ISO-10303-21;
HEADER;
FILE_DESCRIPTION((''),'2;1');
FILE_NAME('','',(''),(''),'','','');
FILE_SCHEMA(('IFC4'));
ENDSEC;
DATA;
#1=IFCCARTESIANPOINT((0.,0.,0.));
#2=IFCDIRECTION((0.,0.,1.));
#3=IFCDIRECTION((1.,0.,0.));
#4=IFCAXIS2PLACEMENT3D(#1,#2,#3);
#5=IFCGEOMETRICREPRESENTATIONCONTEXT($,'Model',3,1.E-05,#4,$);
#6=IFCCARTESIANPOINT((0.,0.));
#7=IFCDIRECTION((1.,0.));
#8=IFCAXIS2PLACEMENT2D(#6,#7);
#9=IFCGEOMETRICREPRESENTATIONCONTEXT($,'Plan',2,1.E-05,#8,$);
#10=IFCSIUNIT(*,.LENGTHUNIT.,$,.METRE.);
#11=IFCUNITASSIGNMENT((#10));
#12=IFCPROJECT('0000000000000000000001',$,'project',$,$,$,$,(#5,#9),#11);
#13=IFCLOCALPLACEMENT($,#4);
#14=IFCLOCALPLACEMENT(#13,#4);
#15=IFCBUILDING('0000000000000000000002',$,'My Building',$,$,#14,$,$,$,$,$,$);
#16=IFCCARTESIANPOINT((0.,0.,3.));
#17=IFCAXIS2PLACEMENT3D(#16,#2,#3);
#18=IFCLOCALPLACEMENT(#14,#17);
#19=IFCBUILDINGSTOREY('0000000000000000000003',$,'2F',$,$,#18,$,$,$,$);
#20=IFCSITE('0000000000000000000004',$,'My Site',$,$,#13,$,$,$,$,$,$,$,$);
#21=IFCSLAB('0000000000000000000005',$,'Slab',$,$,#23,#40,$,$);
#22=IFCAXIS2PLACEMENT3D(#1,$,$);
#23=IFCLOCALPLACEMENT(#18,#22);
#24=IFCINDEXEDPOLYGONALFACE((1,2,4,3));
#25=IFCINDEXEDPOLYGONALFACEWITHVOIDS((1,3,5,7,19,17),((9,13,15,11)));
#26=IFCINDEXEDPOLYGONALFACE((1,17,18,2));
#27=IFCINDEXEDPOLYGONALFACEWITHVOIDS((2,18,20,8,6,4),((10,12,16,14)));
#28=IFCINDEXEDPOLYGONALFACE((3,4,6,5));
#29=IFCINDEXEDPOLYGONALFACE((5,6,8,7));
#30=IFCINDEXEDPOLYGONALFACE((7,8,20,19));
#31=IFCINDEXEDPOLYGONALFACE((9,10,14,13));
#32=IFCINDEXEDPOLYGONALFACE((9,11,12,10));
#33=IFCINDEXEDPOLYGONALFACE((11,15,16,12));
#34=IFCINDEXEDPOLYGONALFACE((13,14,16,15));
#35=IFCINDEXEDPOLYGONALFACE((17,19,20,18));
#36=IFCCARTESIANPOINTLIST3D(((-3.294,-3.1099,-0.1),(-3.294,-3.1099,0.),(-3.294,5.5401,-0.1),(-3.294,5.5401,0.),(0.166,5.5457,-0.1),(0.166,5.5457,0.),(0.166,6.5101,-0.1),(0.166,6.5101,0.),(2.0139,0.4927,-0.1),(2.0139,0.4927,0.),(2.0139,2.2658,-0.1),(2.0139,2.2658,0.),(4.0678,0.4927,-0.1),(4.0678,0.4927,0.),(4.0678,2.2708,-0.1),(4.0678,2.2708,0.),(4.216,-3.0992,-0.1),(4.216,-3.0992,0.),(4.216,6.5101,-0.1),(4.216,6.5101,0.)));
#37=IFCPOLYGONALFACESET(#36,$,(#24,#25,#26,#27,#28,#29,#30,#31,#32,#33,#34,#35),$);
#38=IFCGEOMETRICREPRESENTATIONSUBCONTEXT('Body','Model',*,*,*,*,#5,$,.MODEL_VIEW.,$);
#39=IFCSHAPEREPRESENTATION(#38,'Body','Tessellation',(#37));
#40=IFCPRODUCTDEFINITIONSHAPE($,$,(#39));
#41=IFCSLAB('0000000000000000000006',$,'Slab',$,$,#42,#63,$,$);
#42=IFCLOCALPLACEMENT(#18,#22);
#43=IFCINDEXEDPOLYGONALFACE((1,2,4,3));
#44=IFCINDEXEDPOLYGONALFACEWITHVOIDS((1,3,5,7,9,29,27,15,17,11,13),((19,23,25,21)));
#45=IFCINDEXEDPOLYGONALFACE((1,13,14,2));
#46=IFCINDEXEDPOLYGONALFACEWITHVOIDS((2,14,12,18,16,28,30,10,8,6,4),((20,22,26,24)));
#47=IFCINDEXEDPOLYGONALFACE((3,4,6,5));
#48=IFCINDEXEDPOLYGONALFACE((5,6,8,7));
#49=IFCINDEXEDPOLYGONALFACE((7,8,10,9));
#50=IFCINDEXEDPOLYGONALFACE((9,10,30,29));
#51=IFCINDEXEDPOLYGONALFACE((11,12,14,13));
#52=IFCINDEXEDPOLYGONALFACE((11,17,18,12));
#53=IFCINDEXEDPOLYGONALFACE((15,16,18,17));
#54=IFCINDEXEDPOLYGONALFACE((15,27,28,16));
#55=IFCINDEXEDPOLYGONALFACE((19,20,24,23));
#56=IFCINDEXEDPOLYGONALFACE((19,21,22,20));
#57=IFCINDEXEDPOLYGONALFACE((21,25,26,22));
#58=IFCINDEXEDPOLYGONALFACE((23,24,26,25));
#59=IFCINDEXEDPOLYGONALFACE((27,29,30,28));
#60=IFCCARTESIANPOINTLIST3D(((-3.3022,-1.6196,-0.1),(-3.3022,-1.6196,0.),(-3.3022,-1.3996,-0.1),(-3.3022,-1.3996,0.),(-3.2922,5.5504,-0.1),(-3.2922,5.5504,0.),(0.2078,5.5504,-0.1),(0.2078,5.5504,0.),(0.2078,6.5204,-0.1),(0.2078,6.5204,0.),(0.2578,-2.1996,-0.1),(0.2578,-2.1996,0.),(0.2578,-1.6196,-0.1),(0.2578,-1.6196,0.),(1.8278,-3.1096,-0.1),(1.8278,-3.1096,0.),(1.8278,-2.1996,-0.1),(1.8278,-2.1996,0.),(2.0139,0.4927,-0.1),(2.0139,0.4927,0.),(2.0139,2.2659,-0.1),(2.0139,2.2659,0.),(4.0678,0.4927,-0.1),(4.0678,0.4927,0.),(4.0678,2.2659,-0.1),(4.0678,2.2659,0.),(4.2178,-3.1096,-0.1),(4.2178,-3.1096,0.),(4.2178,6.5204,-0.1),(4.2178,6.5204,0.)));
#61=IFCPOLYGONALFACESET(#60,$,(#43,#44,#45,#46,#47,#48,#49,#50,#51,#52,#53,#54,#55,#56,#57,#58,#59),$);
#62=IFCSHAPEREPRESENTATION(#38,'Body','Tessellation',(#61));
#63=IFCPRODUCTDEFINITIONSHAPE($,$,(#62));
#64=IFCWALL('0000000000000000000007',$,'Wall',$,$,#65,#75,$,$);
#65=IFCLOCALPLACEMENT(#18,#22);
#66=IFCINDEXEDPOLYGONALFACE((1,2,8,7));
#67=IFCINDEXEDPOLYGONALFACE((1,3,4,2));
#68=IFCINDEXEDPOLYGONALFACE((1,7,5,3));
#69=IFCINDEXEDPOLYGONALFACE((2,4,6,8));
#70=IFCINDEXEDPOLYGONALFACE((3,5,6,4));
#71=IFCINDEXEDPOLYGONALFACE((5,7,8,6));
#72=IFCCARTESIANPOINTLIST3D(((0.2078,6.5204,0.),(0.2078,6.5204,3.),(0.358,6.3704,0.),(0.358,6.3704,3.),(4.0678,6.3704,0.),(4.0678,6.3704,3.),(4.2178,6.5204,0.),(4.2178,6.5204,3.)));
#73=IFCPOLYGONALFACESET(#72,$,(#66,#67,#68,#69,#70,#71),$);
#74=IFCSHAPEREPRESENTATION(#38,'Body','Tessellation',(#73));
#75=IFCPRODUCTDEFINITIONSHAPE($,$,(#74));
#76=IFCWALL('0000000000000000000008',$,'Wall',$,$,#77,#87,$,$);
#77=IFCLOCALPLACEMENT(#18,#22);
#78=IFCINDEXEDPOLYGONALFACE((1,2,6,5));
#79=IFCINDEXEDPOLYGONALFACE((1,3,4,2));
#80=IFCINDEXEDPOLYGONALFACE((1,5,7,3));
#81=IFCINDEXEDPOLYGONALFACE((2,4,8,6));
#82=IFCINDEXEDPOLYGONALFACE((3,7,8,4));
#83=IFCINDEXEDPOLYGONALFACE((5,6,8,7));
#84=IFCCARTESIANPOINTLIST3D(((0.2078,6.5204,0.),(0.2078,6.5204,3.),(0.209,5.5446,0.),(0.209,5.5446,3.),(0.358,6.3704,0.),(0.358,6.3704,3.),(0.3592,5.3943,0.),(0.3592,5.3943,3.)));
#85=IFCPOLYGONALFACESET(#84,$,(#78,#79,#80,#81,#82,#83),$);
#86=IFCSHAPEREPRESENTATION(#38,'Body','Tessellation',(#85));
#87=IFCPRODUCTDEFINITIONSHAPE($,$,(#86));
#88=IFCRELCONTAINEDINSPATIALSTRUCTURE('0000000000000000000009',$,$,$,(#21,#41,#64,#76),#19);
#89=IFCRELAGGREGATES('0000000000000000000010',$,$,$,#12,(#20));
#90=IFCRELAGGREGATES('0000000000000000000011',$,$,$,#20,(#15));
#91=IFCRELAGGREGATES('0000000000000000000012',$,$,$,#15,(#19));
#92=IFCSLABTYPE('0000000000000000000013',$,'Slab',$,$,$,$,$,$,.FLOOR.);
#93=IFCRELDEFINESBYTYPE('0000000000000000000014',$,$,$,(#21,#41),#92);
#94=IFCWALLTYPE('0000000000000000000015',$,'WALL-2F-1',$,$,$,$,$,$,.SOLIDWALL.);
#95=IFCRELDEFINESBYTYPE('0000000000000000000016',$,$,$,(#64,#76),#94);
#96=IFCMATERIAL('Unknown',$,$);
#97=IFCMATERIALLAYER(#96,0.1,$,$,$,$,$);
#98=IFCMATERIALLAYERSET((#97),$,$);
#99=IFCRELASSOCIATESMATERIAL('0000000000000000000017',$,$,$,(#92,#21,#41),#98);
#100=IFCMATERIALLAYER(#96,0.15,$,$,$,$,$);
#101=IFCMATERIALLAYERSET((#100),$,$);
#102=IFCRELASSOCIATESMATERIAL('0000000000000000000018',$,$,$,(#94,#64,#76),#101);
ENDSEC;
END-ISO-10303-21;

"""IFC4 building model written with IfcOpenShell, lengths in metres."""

from ifc_helpers import new_model, si_unit, frame, origin_with_axes, origin_2d_with_axis, place, context, subcontext, project, spatial, line, indexed_curve, outline, extrude, material, layer, layer_set, layer_usage, type_object, element, save


model = new_model("IFC4")

# Units and contexts
model_context = context("Model", 3, precision=1e-05, world=origin_with_axes())
plan_context = context("Plan", 2, precision=1e-05, world=origin_2d_with_axis())
body_context_1 = subcontext(model_context, "Body", "Model", "MODEL_VIEW")
ifc_project = project(units=[si_unit("LENGTHUNIT", "METRE")], contexts=[model_context, plan_context])

# Site, building, storey
site_placement = place(None, origin_with_axes())
site = spatial("IfcSite", under=ifc_project, at=site_placement, Name="My Site")
building_placement = place(site_placement, origin_with_axes())
building = spatial("IfcBuilding", under=site, at=building_placement, Name="My Building")
storey_placement = place(building_placement, frame((0.0, 0.0, 3.0), z_axis=(0.0, 0.0, 1.0), x_axis=(1.0, 0.0, 0.0)))
storey = spatial("IfcBuildingStorey", under=building, at=storey_placement, Name="2F")

# Slabs
ifc_material = material(Name="Unknown")
ifc_layer_1 = layer(ifc_material, 0.1)
ifc_layer_set_1 = layer_set([ifc_layer_1])
ifc_layer_usage_1 = layer_usage(ifc_layer_set_1, "AXIS3", "POSITIVE", -0.1)
slab_type = type_object("IfcSlabType", Name="Slab", PredefinedType="FLOOR", material=ifc_layer_set_1)
slab_1_placement = place(storey_placement, frame((-3.294, 5.5401, 0.0), z_axis=(0.0, 0.0, 1.0), x_axis=(1.0, 0.0, 0.0)))
element("IfcSlab", 1, at=slab_1_placement, inside=storey, type_object=slab_type, material=ifc_layer_usage_1, Name="Slab", context=body_context_1, shape_type="SweptSolid", body=[
    extrude(outline(indexed_curve([(0.0, 0.0), (0.0, -8.65), (7.51, -8.6394), (7.51, 0.97), (3.46, 0.97), (3.46, 0.0056), (0.0, 0.0)]), holes=[indexed_curve([(5.3079, -5.0474), (7.3618, -5.0474), (7.3618, -3.2693), (5.3079, -3.2743), (5.3079, -5.0474)])]), frame((0.0, 0.0, -0.1), z_axis=(0.0, 0.0, 1.0), x_axis=(1.0, 0.0, 0.0)), (0.0, 0.0, 1.0), 0.1),
])
ifc_layer_usage_2 = layer_usage(ifc_layer_set_1, "AXIS3", "POSITIVE", -0.1)
slab_2_placement = place(storey_placement, frame((-3.3022, -1.3996, 0.0), z_axis=(0.0, 0.0, 1.0), x_axis=(1.0, 0.0, 0.0)))
element("IfcSlab", 2, at=slab_2_placement, inside=storey, type_object=slab_type, material=ifc_layer_usage_2, Name="Slab", context=body_context_1, shape_type="SweptSolid", body=[
    extrude(outline(indexed_curve([(0.01, 6.95), (3.51, 6.95), (3.51, 7.92), (7.52, 7.92), (7.52, -1.71), (5.13, -1.71), (5.13, -0.8), (3.56, -0.8), (3.56, -0.22), (0.0, -0.22), (0.0, 0.0), (0.01, 6.95)]), holes=[indexed_curve([(5.3161, 1.8923), (7.37, 1.8923), (7.37, 3.6655), (5.3161, 3.6655), (5.3161, 1.8923)])]), frame((0.0, 0.0, -0.1), z_axis=(0.0, 0.0, 1.0), x_axis=(1.0, 0.0, 0.0)), (0.0, 0.0, 1.0), 0.1),
])

# Shared definitions
ifc_layer_2 = layer(ifc_material, 0.15)
ifc_layer_set_2 = layer_set([ifc_layer_2])
wall_type_1 = type_object("IfcWallType", Name="WALL-2F-1", PredefinedType="SOLIDWALL", material=ifc_layer_set_2)

# Walls
ifc_layer_usage_3 = layer_usage(ifc_layer_set_2, "AXIS2", "POSITIVE", 0.0)
wall_1_placement = place(storey_placement, frame((4.2178, 6.5204, 0.0), z_axis=(0.0, 0.0, 1.0), x_axis=(-1.0, 0.0, 0.0)))
element("IfcWall", 3, at=wall_1_placement, inside=storey, type_object=wall_type_1, material=ifc_layer_usage_3, Name="Wall", context=body_context_1, shape_type="SweptSolid", body=[
    extrude(outline(indexed_curve([(0.0, 0.0), (0.15, 0.15), (3.8598, 0.15), (4.01, 0.0)], segments=[line(1, 2, 3, 4, 1)])), origin_with_axes(), (0.0, 0.0, 1.0), 3.0),
])
ifc_layer_usage_4 = layer_usage(ifc_layer_set_2, "AXIS2", "POSITIVE", 0.0)
wall_2_placement = place(storey_placement, frame((0.2078, 6.5204, 0.0), z_axis=(0.0, 0.0, 1.0), x_axis=(0.001246, -0.999999, 0.0)))
element("IfcWall", 4, at=wall_2_placement, inside=storey, type_object=wall_type_1, material=ifc_layer_usage_4, Name="Wall", context=body_context_1, shape_type="SweptSolid", body=[
    extrude(outline(indexed_curve([(0.0, 0.0), (0.1502, 0.15), (1.1263, 0.15), (0.9758, 0.0)], segments=[line(1, 2, 3, 4, 1)])), origin_with_axes(), (0.0, 0.0, 1.0), 3.0),
])

save(model, "model.ifc")
